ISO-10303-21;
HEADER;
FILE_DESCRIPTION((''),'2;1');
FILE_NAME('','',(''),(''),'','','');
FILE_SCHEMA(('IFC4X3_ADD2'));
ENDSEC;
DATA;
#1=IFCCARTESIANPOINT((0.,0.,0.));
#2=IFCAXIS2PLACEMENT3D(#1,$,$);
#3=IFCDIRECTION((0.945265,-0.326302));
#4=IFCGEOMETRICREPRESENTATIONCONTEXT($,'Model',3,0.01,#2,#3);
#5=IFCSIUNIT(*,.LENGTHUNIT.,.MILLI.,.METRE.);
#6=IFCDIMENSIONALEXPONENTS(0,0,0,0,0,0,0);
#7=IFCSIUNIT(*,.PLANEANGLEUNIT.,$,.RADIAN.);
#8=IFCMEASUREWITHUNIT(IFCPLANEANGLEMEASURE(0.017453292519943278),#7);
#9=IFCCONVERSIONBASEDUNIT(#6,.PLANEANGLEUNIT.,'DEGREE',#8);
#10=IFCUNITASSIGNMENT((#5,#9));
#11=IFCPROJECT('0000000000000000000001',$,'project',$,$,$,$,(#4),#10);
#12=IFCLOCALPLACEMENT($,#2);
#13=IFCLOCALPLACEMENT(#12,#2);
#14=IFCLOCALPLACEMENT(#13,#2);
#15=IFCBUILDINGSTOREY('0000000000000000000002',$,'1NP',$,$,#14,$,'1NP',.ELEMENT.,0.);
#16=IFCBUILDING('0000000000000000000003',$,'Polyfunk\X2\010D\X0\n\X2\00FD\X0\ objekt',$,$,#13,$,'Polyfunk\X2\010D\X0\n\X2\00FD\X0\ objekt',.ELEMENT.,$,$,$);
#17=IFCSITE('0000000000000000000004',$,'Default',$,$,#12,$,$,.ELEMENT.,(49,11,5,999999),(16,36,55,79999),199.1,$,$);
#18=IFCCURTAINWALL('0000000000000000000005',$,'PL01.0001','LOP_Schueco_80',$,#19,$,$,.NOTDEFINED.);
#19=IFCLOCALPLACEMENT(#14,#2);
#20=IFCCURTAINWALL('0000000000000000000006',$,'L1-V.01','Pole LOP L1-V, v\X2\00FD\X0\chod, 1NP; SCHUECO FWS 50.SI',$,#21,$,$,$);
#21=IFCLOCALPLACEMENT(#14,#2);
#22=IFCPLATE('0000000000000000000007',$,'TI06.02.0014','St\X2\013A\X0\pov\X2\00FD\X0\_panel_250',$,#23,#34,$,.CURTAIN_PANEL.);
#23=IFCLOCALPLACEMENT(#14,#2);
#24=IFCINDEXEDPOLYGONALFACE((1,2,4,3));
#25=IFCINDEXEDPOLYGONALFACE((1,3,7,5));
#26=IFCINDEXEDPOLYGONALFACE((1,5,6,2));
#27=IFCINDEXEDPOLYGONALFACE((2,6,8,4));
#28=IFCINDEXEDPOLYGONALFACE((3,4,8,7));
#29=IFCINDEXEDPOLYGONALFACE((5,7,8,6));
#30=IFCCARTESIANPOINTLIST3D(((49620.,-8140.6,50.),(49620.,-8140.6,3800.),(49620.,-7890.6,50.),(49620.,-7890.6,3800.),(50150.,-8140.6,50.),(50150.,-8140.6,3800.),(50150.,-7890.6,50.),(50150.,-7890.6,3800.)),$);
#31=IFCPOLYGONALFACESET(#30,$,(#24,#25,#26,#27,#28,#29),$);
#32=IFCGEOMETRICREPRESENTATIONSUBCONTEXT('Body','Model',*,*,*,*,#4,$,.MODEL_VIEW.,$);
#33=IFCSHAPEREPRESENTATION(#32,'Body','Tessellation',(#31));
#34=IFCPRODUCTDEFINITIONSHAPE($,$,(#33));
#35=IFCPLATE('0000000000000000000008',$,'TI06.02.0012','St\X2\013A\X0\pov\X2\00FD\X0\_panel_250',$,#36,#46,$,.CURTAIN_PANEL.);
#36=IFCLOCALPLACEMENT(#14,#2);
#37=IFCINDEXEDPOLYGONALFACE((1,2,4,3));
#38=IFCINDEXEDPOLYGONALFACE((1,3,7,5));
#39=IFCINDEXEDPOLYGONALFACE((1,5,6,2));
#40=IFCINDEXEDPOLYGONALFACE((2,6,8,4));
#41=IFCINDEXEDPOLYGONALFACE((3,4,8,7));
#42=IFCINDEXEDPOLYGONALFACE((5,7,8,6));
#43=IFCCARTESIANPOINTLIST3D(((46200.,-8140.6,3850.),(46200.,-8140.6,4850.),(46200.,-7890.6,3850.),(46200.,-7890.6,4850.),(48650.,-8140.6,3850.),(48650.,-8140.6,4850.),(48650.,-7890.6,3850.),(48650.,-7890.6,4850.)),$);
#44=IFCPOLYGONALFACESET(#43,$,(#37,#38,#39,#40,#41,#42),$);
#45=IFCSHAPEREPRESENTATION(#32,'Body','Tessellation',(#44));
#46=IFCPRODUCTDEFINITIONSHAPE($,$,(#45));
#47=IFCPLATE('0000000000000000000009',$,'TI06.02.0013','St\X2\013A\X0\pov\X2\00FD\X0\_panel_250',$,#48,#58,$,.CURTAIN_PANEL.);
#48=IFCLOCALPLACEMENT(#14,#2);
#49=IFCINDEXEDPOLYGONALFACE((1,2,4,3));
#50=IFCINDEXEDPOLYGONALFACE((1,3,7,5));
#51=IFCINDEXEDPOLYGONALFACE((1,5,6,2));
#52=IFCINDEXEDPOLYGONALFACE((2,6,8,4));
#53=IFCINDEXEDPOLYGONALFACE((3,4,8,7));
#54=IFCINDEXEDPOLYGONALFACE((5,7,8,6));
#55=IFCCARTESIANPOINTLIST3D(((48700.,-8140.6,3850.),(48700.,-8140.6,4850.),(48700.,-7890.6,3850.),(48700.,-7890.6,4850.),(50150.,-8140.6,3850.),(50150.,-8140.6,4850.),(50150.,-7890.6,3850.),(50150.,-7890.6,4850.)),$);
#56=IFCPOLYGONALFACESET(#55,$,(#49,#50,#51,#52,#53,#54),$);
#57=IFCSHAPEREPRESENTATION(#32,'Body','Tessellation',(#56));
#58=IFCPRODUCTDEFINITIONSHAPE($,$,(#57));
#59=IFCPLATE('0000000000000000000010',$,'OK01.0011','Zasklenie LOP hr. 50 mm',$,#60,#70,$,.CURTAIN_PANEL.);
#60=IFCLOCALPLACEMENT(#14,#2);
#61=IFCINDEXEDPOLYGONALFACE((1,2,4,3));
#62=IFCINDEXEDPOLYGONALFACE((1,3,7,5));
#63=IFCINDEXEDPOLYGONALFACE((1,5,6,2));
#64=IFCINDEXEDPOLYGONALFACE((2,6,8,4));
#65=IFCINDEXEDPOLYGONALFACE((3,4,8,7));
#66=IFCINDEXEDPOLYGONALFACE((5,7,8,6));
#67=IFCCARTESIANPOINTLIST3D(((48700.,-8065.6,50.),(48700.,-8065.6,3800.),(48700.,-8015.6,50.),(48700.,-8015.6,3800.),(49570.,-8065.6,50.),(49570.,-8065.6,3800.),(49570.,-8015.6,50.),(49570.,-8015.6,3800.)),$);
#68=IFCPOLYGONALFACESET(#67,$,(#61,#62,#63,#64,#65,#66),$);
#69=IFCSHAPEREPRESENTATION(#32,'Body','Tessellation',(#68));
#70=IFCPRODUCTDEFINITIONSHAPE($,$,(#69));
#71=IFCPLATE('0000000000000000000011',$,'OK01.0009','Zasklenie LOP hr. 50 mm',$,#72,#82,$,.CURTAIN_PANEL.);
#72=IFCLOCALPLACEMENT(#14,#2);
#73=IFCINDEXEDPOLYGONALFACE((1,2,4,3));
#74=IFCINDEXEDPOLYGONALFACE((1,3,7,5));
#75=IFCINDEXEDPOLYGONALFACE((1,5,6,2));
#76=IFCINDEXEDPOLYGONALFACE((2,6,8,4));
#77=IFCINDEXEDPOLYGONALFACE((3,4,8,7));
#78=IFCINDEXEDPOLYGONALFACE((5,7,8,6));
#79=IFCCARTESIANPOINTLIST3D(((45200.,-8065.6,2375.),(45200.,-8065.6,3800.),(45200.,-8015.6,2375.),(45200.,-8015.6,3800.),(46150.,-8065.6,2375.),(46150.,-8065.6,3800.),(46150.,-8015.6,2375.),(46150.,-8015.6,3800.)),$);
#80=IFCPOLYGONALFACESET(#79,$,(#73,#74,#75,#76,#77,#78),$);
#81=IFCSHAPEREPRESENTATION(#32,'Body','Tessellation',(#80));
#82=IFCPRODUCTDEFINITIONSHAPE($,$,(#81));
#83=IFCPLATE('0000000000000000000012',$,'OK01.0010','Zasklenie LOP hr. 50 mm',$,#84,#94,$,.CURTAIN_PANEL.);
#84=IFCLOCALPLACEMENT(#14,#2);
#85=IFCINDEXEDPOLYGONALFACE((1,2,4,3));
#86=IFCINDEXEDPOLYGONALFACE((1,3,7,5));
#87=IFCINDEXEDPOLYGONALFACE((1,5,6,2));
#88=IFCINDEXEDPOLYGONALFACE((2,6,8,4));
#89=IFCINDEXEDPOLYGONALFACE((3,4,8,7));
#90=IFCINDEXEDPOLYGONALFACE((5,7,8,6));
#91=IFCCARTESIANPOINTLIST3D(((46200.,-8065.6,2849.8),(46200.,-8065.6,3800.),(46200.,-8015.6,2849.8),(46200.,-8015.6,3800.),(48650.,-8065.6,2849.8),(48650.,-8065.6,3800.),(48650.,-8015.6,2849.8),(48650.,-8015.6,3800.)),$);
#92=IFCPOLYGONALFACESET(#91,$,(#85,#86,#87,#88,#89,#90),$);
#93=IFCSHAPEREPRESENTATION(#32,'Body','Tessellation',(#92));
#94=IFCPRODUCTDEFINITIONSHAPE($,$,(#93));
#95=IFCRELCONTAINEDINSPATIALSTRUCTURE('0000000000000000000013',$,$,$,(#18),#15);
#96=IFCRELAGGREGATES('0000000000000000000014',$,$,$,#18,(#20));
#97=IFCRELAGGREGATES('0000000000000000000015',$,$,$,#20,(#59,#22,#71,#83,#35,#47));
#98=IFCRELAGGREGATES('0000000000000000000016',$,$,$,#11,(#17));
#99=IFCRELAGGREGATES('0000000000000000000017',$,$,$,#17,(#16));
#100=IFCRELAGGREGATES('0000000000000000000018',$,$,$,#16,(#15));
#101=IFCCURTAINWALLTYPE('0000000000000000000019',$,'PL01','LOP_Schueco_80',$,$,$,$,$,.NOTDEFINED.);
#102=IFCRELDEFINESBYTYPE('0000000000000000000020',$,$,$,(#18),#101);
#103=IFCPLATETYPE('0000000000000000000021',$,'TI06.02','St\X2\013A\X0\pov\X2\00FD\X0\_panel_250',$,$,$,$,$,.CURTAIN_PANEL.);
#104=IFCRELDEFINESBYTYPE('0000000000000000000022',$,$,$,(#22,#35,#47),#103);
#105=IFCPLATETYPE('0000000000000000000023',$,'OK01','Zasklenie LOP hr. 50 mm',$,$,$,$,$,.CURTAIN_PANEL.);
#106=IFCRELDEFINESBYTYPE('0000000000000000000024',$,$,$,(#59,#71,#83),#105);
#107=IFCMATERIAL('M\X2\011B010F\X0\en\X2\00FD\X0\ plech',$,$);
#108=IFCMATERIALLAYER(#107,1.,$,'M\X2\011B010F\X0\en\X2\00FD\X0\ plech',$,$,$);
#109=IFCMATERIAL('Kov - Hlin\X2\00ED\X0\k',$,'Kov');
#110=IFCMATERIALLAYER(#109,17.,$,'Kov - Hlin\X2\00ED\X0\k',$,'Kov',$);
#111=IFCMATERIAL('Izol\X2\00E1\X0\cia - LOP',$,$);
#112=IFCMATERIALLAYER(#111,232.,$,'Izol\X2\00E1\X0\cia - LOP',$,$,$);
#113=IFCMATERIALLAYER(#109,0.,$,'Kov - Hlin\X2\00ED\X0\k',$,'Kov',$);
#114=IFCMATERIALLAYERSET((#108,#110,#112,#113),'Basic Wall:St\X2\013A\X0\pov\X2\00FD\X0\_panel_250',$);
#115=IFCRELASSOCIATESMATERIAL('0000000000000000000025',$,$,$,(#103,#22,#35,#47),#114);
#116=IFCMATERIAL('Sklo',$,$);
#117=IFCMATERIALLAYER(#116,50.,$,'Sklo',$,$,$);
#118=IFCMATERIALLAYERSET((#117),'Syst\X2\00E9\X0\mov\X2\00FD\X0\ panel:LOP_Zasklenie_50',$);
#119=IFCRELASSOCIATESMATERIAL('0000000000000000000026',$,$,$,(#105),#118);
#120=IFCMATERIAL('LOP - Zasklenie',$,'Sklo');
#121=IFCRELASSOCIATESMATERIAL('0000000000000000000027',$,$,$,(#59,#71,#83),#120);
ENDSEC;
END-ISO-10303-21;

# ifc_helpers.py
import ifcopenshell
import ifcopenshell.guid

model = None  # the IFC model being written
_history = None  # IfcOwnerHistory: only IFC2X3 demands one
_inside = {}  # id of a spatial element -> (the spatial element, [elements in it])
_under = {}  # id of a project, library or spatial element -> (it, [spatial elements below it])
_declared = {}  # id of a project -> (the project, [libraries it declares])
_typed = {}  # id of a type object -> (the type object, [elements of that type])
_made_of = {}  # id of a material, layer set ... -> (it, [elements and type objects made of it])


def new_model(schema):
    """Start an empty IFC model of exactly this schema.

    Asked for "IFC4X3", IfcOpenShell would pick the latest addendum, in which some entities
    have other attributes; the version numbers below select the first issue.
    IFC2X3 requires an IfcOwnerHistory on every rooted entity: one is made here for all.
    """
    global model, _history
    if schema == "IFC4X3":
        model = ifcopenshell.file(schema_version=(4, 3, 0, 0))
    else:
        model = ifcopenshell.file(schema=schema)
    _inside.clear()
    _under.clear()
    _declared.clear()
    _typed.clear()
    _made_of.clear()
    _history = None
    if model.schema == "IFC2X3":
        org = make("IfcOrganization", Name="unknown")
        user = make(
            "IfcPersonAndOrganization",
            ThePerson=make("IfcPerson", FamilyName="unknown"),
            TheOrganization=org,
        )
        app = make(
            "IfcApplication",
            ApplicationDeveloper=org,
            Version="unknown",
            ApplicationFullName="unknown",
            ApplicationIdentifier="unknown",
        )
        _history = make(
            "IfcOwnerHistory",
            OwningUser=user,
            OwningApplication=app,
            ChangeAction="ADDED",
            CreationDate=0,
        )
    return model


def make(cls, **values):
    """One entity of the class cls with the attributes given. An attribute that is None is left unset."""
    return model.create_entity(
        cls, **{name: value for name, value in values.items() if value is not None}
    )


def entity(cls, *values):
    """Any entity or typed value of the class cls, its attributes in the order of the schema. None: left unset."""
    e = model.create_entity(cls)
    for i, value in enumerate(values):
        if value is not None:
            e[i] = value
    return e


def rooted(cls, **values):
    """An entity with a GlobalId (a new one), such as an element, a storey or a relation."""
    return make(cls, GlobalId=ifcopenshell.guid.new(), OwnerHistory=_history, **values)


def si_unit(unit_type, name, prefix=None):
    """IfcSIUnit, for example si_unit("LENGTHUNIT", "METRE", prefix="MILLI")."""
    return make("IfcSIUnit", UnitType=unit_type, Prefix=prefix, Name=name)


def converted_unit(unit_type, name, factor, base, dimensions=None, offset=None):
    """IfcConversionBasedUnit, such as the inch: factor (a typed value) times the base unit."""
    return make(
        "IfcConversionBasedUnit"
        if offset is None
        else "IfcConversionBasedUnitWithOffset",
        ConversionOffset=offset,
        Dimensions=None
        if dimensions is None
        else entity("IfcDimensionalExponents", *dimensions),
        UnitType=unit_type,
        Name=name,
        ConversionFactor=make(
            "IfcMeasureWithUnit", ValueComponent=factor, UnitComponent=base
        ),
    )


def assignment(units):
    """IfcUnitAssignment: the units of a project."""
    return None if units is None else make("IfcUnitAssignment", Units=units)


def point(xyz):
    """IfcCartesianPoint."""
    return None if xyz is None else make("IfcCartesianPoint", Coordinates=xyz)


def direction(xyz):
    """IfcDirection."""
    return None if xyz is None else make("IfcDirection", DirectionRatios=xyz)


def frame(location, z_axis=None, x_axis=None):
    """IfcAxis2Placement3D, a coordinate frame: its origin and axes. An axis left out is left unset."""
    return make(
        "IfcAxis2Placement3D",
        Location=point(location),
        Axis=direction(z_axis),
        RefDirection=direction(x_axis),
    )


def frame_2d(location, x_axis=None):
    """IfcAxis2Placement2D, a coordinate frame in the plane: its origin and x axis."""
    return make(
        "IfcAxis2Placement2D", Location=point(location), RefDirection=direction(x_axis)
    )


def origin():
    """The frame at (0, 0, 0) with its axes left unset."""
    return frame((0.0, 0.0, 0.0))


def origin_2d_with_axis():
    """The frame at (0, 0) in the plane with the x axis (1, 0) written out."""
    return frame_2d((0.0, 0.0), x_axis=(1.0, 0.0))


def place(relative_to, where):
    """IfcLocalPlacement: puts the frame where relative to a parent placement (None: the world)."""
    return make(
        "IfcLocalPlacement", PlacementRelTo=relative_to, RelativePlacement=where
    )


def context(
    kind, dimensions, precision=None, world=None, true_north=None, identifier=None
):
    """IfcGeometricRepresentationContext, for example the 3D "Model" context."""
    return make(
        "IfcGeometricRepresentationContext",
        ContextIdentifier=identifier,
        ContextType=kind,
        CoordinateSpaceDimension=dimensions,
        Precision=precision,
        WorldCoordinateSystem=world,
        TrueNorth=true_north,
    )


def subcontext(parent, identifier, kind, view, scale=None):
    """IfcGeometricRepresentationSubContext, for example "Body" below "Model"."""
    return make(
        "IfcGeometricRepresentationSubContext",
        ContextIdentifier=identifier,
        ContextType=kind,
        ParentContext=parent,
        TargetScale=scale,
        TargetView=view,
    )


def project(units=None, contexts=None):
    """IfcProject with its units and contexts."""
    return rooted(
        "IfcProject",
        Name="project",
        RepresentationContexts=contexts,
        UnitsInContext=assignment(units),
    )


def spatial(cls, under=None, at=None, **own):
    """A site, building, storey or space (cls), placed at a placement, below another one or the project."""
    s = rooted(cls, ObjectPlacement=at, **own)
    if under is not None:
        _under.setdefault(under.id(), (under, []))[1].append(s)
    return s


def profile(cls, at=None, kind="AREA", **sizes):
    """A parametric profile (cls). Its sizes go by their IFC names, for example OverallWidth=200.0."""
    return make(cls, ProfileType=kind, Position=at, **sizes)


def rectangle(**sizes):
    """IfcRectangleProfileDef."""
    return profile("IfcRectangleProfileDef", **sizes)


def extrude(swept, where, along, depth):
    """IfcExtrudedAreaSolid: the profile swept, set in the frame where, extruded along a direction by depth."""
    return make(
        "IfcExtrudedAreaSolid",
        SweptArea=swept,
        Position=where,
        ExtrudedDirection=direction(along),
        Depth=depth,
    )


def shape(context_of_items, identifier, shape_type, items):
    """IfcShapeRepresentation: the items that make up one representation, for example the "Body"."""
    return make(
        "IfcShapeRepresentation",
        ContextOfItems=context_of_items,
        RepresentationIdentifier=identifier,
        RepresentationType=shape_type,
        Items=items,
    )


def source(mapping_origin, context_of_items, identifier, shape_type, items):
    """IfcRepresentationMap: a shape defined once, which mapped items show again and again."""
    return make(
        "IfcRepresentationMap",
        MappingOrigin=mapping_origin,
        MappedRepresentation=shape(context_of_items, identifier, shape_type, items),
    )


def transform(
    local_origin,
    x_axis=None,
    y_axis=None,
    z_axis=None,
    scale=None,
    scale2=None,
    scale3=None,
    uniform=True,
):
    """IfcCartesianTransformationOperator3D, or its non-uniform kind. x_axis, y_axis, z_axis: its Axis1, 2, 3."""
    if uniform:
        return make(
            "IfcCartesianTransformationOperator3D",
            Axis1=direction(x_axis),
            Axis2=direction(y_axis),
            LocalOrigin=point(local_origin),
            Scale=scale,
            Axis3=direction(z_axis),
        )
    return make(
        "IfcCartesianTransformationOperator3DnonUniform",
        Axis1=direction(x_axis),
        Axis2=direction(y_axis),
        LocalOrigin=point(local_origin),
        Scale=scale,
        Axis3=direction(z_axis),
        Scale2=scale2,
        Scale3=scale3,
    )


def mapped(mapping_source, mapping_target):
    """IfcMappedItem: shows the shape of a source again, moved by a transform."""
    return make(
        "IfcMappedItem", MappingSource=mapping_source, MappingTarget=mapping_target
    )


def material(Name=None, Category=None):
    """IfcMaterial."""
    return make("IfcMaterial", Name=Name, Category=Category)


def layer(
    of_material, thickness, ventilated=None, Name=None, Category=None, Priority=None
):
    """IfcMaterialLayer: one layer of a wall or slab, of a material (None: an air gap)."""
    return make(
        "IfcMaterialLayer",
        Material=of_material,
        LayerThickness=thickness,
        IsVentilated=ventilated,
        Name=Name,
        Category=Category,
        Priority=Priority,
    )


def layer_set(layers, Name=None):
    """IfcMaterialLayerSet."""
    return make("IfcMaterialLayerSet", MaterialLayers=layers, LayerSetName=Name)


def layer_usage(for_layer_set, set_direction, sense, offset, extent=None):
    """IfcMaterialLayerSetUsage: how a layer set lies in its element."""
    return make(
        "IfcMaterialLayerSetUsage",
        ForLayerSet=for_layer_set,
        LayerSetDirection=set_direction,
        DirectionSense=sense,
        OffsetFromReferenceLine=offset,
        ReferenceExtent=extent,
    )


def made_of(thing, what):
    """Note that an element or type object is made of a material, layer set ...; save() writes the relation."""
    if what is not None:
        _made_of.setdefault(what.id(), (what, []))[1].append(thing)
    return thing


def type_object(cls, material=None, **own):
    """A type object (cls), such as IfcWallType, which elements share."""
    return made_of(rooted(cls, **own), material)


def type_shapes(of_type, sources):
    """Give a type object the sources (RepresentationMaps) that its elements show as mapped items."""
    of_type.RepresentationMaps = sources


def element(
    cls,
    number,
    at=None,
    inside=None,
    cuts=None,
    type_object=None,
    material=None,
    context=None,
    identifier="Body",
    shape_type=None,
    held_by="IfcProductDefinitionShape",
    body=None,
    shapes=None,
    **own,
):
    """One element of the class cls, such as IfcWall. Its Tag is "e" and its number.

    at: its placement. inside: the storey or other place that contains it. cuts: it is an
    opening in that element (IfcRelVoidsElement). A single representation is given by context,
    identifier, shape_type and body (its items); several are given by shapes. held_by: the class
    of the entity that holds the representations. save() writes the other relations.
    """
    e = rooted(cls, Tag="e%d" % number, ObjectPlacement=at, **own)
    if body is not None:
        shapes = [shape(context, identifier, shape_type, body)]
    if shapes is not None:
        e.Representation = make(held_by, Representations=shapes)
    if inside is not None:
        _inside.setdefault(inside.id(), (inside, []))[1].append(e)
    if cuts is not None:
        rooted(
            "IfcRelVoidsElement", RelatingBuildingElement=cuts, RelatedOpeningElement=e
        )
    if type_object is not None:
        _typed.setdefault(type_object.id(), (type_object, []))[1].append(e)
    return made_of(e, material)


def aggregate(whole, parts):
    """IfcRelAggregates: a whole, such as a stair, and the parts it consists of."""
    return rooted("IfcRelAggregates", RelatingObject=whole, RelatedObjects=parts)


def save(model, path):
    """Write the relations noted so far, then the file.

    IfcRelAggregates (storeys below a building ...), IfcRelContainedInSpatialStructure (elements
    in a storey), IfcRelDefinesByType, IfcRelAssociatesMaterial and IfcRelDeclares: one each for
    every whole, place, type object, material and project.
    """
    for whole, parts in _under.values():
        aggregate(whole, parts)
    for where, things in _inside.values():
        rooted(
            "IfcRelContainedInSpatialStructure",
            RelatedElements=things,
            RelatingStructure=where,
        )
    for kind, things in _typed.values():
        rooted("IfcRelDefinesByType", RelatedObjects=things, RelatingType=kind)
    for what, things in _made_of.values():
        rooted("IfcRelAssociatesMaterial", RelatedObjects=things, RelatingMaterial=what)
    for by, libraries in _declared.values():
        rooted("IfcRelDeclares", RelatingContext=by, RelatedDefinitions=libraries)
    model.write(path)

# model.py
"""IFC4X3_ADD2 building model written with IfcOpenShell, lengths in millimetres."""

from ifc_helpers import new_model, entity, si_unit, converted_unit, direction, frame, frame_2d, origin, origin_2d_with_axis, place, context, subcontext, project, spatial, rectangle, extrude, source, transform, mapped, material, layer, layer_set, layer_usage, type_object, type_shapes, element, aggregate, save


model = new_model("IFC4X3_ADD2")

# Units and contexts
model_context = context("Model", 3, precision=0.01, world=origin(), true_north=direction((0.945265, -0.326302)))
body_context = subcontext(model_context, "Body", "Model", "MODEL_VIEW")
ifc_project = project(units=[si_unit("LENGTHUNIT", "METRE", prefix="MILLI"), converted_unit("PLANEANGLEUNIT", "DEGREE", entity("IfcPlaneAngleMeasure", 0.017453292519943278), si_unit("PLANEANGLEUNIT", "RADIAN"), dimensions=[0, 0, 0, 0, 0, 0, 0])], contexts=[model_context])

# Site, building, storey
site_placement = place(None, origin())
site = spatial("IfcSite", under=ifc_project, at=site_placement, Name="Default", CompositionType="ELEMENT", RefLatitude=(49, 11, 5, 999999), RefLongitude=(16, 36, 55, 79999), RefElevation=199.1)
building_placement = place(site_placement, origin())
building = spatial("IfcBuilding", under=site, at=building_placement, Name="Polyfunkčný objekt", LongName="Polyfunkčný objekt", CompositionType="ELEMENT")
storey_placement = place(building_placement, origin())
storey = spatial("IfcBuildingStorey", under=building, at=storey_placement, Name="1NP", LongName="1NP", CompositionType="ELEMENT", Elevation=0.0)

# Curtain walls, plates
curtain_wall_type = type_object("IfcCurtainWallType", Name="PL01", Description="LOP_Schueco_80", PredefinedType="NOTDEFINED")
curtain_wall_1_placement = place(storey_placement, origin())
curtain_wall_1 = element("IfcCurtainWall", 1, at=curtain_wall_1_placement, inside=storey, type_object=curtain_wall_type, Name="PL01.0001", Description="LOP_Schueco_80", PredefinedType="NOTDEFINED")
curtain_wall_2 = element("IfcCurtainWall", 2, Name="L1-V.01", Description="Pole LOP L1-V, východ, 1NP; SCHUECO FWS 50.SI")
aggregate(curtain_wall_1, [curtain_wall_2])
ifc_material_1 = material(Name="Měďený plech")
ifc_layer_1 = layer(ifc_material_1, 1.0, Name="Měďený plech")
ifc_material_2 = material(Name="Kov - Hliník", Category="Kov")
ifc_layer_2 = layer(ifc_material_2, 17.0, Name="Kov - Hliník", Category="Kov")
ifc_material_3 = material(Name="Izolácia - LOP")
ifc_layer_3 = layer(ifc_material_3, 232.0, Name="Izolácia - LOP")
ifc_layer_4 = layer(ifc_material_2, 0.0, Name="Kov - Hliník", Category="Kov")
ifc_layer_set_1 = layer_set([ifc_layer_1, ifc_layer_2, ifc_layer_3, ifc_layer_4], Name="Basic Wall:Stĺpový_panel_250")
ifc_layer_usage_1 = layer_usage(ifc_layer_set_1, "AXIS2", "POSITIVE", -125.0)
plate_type_1 = type_object("IfcPlateType", Name="TI06.02", Description="Stĺpový_panel_250", PredefinedType="CURTAIN_PANEL", material=ifc_layer_set_1)
plate_1_placement = place(storey_placement, frame((49620.0, -8015.6, 50.0)))
plate_1 = element("IfcPlate", 3, at=plate_1_placement, type_object=plate_type_1, material=ifc_layer_usage_1, Name="TI06.02.0014", Description="Stĺpový_panel_250", PredefinedType="CURTAIN_PANEL", context=body_context, shape_type="SweptSolid", body=[
    extrude(rectangle(XDim=250.0, YDim=530.0, at=frame_2d((0.0, 0.0), x_axis=(1.0, 0.0))), frame((265.0, 0.0, 0.0), z_axis=(0.0, 0.0, 1.0), x_axis=(0.0, 1.0, 0.0)), (0.0, 0.0, 1.0), 3750.0),
])
ifc_layer_usage_2 = layer_usage(ifc_layer_set_1, "AXIS2", "POSITIVE", -125.0)
plate_2_placement = place(storey_placement, frame((46200.0, -8015.6, 3850.0)))
plate_2 = element("IfcPlate", 4, at=plate_2_placement, type_object=plate_type_1, material=ifc_layer_usage_2, Name="TI06.02.0012", Description="Stĺpový_panel_250", PredefinedType="CURTAIN_PANEL", context=body_context, shape_type="SweptSolid", body=[
    extrude(rectangle(XDim=250.0, YDim=2450.0, at=origin_2d_with_axis()), frame((1225.0, 0.0, 0.0), z_axis=(0.0, 0.0, 1.0), x_axis=(0.0, 1.0, 0.0)), (0.0, 0.0, 1.0), 1000.0),
])
ifc_layer_usage_3 = layer_usage(ifc_layer_set_1, "AXIS2", "POSITIVE", -125.0)
plate_3_placement = place(storey_placement, frame((48700.0, -8015.6, 3850.0)))
plate_3 = element("IfcPlate", 5, at=plate_3_placement, type_object=plate_type_1, material=ifc_layer_usage_3, Name="TI06.02.0013", Description="Stĺpový_panel_250", PredefinedType="CURTAIN_PANEL", context=body_context, shape_type="SweptSolid", body=[
    extrude(rectangle(XDim=250.0, YDim=1450.0, at=frame_2d((0.0, 0.0), x_axis=(1.0, 0.0))), frame((725.0, 0.0, 0.0), z_axis=(0.0, 0.0, 1.0), x_axis=(0.0, 1.0, 0.0)), (0.0, 0.0, 1.0), 1000.0),
])
ifc_material_4 = material(Name="LOP - Zasklenie", Category="Sklo")
ifc_material_5 = material(Name="Sklo")
ifc_layer_5 = layer(ifc_material_5, 50.0, Name="Sklo")
ifc_layer_set_2 = layer_set([ifc_layer_5], Name="Systémový panel:LOP_Zasklenie_50")
plate_type_2 = type_object("IfcPlateType", Name="OK01", Description="Zasklenie LOP hr. 50 mm", PredefinedType="CURTAIN_PANEL", material=ifc_layer_set_2)
shared_shape_1 = source(origin(), body_context, "Body", "SweptSolid", [
    extrude(rectangle(XDim=3750.0, YDim=870.0, at=frame_2d((-331.2, 0.0), x_axis=(1.0, 0.0))), frame((0.0, -50.0, 2206.2), z_axis=(0.0, 1.0, 0.0), x_axis=(0.0, 0.0, 1.0)), (0.0, 0.0, 1.0), 50.0),
])
plate_4_placement = place(curtain_wall_1_placement, frame((49135.0, -8015.6, 50.0)))
plate_4 = element("IfcPlate", 6, at=plate_4_placement, type_object=plate_type_2, material=ifc_material_4, Name="OK01.0011", Description="Zasklenie LOP hr. 50 mm", PredefinedType="CURTAIN_PANEL", context=body_context, shape_type="MappedRepresentation", body=[
    mapped(shared_shape_1, transform((0.0, 0.0, 0.0), scale=1.0)),
])
shared_shape_2 = source(origin(), body_context, "Body", "SweptSolid", [
    extrude(rectangle(XDim=1425.0, YDim=950.0, at=frame_2d((87.6, 0.0), x_axis=(1.0, 0.0))), frame((0.0, -50.0, 624.9), z_axis=(0.0, 1.0, 0.0), x_axis=(0.0, 0.0, 1.0)), (0.0, 0.0, 1.0), 50.0),
])
plate_5_placement = place(curtain_wall_1_placement, frame((45675.0, -8015.6, 2375.0)))
plate_5 = element("IfcPlate", 7, at=plate_5_placement, type_object=plate_type_2, material=ifc_material_4, Name="OK01.0009", Description="Zasklenie LOP hr. 50 mm", PredefinedType="CURTAIN_PANEL", context=body_context, shape_type="MappedRepresentation", body=[
    mapped(shared_shape_2, transform((0.0, 0.0, 0.0), scale=1.0)),
])
shared_shape_3 = source(origin(), body_context, "Body", "SweptSolid", [
    extrude(rectangle(XDim=50.0, YDim=2450.0, at=origin_2d_with_axis()), frame((0.0, -25.0, 0.0), z_axis=(0.0, 0.0, 1.0), x_axis=(0.0, 1.0, 0.0)), (0.0, 0.0, 1.0), 950.2),
])
type_shapes(plate_type_2, [shared_shape_1, shared_shape_2, shared_shape_3])
plate_6_placement = place(curtain_wall_1_placement, frame((47425.0, -8015.6, 2849.8)))
plate_6 = element("IfcPlate", 8, at=plate_6_placement, type_object=plate_type_2, material=ifc_material_4, Name="OK01.0010", Description="Zasklenie LOP hr. 50 mm", PredefinedType="CURTAIN_PANEL", context=body_context, shape_type="MappedRepresentation", body=[
    mapped(shared_shape_3, transform((0.0, 0.0, 0.0), scale=1.0)),
])
aggregate(curtain_wall_2, [plate_4, plate_1, plate_5, plate_6, plate_2, plate_3])

save(model, "model.ifc")
